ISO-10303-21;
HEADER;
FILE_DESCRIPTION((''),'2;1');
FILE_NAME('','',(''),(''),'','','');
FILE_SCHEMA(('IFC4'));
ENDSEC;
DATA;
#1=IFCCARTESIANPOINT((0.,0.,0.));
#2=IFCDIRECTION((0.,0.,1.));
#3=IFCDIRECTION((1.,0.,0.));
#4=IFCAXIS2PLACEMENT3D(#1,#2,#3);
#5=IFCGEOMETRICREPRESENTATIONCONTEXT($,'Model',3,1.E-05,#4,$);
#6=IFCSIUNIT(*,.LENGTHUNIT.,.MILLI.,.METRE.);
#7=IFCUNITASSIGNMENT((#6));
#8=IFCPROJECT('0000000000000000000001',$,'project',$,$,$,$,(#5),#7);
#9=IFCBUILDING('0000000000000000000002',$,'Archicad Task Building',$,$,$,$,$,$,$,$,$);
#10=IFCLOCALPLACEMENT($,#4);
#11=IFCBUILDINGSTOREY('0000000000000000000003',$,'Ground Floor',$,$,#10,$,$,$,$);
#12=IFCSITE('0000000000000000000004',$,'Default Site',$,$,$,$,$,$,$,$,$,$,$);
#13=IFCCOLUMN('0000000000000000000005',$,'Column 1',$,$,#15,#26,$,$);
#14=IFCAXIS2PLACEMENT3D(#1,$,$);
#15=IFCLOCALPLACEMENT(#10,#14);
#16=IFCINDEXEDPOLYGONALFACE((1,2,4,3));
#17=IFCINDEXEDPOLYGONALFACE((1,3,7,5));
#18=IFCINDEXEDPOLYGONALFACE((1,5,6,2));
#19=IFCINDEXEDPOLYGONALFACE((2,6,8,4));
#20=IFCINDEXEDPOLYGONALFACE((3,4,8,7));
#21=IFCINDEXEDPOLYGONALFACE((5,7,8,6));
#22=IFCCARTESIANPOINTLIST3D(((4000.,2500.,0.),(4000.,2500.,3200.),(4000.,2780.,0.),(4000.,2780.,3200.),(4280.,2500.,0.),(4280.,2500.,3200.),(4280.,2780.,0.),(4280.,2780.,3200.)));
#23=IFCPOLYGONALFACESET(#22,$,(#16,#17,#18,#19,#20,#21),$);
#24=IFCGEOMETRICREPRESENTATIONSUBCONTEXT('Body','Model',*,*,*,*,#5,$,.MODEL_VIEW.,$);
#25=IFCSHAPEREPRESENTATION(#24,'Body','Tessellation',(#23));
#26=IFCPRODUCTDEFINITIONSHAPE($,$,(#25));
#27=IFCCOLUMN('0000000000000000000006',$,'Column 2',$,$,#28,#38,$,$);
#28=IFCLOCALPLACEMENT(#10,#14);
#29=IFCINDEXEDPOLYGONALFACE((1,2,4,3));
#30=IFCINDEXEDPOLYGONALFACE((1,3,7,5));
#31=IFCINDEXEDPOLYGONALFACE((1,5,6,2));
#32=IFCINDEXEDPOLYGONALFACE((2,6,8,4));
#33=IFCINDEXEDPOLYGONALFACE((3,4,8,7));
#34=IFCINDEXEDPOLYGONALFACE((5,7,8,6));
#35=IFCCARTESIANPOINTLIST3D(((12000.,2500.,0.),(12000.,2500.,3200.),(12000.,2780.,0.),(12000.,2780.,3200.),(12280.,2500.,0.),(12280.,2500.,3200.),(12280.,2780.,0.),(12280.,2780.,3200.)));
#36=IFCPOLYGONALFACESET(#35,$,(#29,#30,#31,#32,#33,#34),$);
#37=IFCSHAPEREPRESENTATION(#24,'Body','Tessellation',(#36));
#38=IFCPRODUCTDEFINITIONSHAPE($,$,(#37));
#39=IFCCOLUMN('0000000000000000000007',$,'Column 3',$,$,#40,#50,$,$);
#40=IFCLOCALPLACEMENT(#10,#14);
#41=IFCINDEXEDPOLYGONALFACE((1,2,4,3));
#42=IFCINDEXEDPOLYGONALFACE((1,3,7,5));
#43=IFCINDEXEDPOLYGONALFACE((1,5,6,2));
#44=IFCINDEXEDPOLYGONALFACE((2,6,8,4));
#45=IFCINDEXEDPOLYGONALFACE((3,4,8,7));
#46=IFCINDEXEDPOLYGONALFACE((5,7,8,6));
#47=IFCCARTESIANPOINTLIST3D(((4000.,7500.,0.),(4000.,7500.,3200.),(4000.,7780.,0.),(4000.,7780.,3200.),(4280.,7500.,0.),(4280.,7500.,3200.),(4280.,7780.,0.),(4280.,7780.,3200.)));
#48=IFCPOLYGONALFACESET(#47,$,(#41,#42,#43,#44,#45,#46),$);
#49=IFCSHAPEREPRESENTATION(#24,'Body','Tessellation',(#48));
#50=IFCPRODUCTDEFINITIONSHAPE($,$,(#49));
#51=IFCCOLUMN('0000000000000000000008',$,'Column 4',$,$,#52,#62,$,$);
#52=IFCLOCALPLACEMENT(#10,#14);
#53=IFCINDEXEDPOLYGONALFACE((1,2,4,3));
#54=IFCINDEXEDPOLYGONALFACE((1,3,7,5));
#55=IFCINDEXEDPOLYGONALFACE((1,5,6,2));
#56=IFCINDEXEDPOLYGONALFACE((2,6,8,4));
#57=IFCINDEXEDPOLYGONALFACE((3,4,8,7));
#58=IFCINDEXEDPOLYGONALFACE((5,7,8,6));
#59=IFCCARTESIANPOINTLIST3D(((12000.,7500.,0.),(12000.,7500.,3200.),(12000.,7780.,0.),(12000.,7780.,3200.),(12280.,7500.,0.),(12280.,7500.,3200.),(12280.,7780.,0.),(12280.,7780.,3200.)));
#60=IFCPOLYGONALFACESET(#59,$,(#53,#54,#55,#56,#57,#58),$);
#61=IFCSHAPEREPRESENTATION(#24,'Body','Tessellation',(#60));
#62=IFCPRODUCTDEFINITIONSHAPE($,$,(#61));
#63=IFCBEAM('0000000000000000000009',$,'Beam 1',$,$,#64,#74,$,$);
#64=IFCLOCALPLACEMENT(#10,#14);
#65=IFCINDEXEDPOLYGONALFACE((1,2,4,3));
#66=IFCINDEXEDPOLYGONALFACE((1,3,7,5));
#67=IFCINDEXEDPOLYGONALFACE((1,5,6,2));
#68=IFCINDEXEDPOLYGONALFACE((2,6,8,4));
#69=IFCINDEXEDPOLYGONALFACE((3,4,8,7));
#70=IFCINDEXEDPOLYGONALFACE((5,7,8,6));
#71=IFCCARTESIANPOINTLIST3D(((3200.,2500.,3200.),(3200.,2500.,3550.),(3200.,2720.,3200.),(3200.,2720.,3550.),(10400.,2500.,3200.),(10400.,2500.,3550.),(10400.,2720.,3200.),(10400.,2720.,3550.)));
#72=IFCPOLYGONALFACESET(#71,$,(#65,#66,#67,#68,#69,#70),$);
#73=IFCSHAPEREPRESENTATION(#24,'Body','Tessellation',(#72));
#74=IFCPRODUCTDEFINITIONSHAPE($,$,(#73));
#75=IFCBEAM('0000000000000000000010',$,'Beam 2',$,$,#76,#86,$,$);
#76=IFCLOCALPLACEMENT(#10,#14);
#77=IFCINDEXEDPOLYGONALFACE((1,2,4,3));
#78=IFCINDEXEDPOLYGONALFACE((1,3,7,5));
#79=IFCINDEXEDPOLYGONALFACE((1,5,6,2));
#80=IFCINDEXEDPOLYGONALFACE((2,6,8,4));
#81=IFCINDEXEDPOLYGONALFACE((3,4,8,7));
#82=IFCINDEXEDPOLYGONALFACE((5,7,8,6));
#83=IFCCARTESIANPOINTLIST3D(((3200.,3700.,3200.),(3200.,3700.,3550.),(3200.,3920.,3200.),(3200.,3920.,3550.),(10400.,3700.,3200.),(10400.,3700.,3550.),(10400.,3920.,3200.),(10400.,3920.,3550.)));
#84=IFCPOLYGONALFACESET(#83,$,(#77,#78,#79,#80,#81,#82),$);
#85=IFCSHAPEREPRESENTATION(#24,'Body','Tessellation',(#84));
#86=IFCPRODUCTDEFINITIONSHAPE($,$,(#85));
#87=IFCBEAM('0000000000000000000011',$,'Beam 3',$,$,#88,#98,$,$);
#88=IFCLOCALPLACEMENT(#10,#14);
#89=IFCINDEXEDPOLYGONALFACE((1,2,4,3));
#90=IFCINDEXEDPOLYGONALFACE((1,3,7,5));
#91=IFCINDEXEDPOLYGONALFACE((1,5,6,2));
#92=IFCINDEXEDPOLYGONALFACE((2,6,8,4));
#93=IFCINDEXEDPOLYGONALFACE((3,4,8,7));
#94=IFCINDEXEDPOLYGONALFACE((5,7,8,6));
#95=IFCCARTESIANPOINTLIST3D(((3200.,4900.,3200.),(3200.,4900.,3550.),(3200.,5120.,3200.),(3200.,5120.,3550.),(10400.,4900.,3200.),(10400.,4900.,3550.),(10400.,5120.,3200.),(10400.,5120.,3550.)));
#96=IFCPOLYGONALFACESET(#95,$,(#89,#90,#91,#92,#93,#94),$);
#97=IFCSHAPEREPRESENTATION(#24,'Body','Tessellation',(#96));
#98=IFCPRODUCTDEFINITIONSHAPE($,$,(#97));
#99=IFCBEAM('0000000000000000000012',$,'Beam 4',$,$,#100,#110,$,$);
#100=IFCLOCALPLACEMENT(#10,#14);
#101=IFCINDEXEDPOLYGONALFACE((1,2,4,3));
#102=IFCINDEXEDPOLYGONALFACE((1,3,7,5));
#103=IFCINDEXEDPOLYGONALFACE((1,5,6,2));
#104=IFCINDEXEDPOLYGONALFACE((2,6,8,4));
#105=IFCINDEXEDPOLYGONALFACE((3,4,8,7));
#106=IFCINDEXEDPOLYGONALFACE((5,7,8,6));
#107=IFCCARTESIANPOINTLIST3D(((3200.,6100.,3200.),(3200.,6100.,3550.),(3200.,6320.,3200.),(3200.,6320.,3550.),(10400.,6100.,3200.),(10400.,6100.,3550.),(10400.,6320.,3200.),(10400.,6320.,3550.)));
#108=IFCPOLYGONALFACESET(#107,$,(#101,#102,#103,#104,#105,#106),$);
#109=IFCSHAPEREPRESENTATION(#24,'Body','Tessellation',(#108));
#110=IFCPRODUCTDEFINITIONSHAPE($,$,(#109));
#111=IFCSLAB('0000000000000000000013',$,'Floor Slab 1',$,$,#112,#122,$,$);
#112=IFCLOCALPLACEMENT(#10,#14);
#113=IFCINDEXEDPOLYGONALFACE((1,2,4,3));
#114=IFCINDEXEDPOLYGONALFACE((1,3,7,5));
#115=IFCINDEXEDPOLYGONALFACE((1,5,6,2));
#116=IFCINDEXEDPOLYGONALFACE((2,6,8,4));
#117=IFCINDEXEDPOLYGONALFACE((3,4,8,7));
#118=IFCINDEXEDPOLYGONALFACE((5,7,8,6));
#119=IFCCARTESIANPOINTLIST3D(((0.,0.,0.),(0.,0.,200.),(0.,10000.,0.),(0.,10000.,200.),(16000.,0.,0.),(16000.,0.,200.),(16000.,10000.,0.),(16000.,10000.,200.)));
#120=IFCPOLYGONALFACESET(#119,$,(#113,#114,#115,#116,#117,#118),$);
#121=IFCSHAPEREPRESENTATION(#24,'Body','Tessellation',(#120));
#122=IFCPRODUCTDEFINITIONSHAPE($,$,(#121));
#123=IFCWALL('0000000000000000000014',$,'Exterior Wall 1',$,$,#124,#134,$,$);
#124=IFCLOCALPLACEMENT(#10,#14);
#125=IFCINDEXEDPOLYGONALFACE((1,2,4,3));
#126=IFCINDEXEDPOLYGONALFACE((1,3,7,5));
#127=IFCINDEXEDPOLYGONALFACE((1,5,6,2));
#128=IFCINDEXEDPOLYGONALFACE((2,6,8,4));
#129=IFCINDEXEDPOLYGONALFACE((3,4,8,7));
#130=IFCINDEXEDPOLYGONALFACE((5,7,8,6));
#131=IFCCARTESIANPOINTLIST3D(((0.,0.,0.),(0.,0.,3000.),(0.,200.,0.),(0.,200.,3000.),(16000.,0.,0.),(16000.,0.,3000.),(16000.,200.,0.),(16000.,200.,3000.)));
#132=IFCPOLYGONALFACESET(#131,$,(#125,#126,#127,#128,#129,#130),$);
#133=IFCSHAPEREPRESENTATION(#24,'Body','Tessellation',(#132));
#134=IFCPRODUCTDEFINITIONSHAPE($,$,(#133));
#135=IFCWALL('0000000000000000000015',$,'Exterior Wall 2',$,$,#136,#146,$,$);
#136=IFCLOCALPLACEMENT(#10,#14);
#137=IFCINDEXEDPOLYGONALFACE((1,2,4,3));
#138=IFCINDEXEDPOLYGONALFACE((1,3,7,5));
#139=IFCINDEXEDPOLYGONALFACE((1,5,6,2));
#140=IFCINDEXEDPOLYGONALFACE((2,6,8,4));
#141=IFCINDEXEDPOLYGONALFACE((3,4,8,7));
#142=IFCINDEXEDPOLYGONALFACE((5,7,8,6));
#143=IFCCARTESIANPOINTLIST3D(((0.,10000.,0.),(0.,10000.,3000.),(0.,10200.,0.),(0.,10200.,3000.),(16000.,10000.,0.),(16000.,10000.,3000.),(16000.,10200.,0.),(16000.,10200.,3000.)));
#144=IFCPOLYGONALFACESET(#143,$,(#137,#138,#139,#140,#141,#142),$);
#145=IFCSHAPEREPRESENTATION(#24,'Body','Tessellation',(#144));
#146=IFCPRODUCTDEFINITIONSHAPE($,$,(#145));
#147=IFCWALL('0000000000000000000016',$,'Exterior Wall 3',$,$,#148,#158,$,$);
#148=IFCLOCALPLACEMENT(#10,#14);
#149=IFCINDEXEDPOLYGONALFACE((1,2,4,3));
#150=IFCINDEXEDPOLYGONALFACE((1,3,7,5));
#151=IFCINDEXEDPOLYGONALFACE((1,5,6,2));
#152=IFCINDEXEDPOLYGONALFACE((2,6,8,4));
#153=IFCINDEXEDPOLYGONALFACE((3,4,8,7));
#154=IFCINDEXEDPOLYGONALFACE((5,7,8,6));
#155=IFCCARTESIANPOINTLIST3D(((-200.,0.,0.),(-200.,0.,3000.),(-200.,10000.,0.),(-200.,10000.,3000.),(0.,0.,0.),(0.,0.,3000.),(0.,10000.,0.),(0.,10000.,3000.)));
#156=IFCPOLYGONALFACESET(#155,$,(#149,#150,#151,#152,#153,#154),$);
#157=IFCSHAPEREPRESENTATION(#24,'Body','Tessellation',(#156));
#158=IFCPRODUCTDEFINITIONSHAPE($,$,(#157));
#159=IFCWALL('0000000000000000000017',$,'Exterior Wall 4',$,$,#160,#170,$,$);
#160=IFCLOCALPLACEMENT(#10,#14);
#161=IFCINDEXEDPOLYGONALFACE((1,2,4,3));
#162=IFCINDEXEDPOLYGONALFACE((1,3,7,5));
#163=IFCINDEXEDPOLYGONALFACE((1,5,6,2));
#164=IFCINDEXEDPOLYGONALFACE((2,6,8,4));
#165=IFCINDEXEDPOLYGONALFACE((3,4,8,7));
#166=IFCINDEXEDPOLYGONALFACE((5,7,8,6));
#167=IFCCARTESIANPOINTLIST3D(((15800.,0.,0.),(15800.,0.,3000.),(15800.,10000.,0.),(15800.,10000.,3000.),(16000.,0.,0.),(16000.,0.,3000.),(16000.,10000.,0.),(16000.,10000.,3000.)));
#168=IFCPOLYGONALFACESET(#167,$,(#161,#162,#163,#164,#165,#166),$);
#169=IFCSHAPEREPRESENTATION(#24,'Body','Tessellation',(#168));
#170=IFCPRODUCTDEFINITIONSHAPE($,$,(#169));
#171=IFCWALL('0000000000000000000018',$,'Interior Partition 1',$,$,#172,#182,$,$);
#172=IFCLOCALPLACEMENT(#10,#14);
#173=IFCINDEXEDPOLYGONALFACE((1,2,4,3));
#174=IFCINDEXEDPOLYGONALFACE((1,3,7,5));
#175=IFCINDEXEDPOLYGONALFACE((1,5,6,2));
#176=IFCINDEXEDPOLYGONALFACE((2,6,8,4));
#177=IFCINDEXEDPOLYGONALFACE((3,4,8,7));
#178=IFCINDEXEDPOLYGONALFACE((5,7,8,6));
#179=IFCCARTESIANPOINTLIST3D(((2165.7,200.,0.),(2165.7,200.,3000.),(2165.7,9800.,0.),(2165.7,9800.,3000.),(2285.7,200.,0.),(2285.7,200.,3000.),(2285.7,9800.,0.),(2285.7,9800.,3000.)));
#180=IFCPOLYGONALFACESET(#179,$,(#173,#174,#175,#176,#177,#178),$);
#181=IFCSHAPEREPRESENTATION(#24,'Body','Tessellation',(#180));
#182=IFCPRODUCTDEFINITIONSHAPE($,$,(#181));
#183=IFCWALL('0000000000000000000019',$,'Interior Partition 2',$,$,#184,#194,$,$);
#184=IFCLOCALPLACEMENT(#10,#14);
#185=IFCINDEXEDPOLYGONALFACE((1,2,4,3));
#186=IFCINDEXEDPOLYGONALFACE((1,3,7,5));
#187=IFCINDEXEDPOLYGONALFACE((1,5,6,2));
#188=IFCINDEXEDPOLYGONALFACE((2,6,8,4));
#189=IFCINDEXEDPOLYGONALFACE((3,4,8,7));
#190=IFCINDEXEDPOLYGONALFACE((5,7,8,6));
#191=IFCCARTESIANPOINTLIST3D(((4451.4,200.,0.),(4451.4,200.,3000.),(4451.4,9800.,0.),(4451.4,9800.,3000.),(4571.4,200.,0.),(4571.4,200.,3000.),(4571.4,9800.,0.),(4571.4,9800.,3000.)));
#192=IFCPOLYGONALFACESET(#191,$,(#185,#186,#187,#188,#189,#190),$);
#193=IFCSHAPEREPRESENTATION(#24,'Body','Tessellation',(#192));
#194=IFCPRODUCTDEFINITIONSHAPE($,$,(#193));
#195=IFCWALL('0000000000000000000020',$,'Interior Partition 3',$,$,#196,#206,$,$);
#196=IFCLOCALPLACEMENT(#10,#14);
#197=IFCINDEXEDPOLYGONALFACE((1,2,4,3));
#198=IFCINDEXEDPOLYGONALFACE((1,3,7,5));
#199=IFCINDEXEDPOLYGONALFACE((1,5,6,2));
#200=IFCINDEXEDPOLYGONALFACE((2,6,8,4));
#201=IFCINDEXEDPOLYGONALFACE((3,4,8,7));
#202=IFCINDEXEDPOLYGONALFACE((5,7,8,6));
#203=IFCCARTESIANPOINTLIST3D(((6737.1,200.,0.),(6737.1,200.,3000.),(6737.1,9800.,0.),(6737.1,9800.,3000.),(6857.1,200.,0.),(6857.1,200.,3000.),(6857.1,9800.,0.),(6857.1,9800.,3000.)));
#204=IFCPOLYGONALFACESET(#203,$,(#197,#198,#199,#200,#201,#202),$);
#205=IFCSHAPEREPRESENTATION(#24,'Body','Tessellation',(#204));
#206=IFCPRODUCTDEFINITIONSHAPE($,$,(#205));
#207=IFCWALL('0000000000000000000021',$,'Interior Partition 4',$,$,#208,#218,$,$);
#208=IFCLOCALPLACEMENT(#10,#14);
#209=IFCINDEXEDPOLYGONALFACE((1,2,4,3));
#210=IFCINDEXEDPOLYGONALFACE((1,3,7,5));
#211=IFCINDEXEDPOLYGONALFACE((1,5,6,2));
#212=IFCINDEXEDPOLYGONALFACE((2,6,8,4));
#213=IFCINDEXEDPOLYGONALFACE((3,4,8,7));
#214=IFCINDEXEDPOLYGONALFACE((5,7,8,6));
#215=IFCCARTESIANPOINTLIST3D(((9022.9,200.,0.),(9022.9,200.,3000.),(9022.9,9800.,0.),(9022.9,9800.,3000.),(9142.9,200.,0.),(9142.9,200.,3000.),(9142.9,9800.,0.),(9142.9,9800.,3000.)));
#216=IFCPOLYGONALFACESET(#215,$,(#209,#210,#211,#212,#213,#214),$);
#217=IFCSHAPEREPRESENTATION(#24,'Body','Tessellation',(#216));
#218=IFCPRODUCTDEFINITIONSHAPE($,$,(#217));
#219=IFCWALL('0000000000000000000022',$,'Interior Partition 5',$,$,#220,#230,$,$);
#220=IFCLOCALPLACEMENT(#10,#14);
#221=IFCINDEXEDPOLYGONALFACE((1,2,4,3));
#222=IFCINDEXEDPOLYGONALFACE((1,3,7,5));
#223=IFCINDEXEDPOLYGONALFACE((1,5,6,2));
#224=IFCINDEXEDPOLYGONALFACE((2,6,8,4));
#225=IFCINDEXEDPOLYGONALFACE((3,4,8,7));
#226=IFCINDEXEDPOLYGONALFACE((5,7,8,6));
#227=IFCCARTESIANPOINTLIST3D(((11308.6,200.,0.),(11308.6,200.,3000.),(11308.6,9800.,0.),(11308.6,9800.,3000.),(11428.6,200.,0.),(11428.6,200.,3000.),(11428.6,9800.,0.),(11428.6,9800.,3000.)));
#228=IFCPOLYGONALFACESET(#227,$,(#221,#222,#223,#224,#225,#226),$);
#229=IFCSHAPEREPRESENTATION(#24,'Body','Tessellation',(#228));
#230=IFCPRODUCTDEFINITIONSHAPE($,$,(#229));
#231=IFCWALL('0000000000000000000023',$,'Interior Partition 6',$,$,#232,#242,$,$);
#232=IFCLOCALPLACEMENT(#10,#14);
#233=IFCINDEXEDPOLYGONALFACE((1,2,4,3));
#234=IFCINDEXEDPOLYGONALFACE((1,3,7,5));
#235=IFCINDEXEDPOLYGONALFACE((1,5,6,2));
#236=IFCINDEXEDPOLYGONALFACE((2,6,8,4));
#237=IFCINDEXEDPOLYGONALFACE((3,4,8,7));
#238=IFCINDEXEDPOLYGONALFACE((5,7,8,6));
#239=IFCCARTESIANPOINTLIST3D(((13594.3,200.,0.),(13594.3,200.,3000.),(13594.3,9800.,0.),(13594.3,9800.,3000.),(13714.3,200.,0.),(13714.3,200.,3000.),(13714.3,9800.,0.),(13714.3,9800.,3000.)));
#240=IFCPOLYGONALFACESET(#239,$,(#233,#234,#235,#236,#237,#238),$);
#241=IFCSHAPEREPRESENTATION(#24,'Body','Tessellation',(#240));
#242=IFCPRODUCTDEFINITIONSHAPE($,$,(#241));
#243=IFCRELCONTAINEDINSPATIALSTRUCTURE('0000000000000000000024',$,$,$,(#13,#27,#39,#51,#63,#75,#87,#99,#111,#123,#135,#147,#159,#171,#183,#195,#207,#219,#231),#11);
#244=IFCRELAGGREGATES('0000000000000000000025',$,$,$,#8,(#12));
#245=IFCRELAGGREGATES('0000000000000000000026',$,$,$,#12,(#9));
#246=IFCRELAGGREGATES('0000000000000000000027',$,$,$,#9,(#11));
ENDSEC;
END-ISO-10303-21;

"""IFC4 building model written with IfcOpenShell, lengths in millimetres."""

from ifc_helpers import new_model, si_unit, frame, origin_with_axes, place, context, subcontext, project, spatial, indexed_curve, outline, extrude, element, save


model = new_model("IFC4")

# Units and contexts
model_context = context("Model", 3, precision=1e-05, world=origin_with_axes())
body_context = subcontext(model_context, "Body", "Model", "MODEL_VIEW")
ifc_project = project(units=[si_unit("LENGTHUNIT", "METRE", prefix="MILLI")], contexts=[model_context])

# Site, building, storey
site = spatial("IfcSite", under=ifc_project, Name="Default Site")
building = spatial("IfcBuilding", under=site, Name="Archicad Task Building")
storey_placement = place(None, origin_with_axes())
storey = spatial("IfcBuildingStorey", under=building, at=storey_placement, Name="Ground Floor")

# Columns
for number, where, z_axis, x_axis, name in (
    (1, (4000.0, 2500.0, 0.0), (0.0, 0.0, 1.0), (1.0, 0.0, 0.0), "Column 1"),
    (2, (12000.0, 2500.0, 0.0), (0.0, 0.0, 1.0), (1.0, 0.0, 0.0), "Column 2"),
    (3, (4000.0, 7500.0, 0.0), (0.0, 0.0, 1.0), (1.0, 0.0, 0.0), "Column 3"),
    (4, (12000.0, 7500.0, 0.0), (0.0, 0.0, 1.0), (1.0, 0.0, 0.0), "Column 4"),
):
    element("IfcColumn", number, at=place(storey_placement, frame(where, z_axis=z_axis, x_axis=x_axis)), inside=storey, Name=name, context=body_context, shape_type="SweptSolid", body=[
        extrude(outline(indexed_curve([(0.0, 0.0), (0.0, 280.0), (280.0, 280.0), (280.0, 0.0), (0.0, 0.0)], self_intersect=False)), origin_with_axes(), (0.0, 0.0, 1.0), 3200.0),
    ])

# Beams
for number, where, z_axis, x_axis, name in (
    (5, (3200.0, 2500.0, 3200.0), (0.0, 0.0, 1.0), (1.0, 0.0, 0.0), "Beam 1"),
    (6, (3200.0, 3700.0, 3200.0), (0.0, 0.0, 1.0), (1.0, 0.0, 0.0), "Beam 2"),
    (7, (3200.0, 4900.0, 3200.0), (0.0, 0.0, 1.0), (1.0, 0.0, 0.0), "Beam 3"),
    (8, (3200.0, 6100.0, 3200.0), (0.0, 0.0, 1.0), (1.0, 0.0, 0.0), "Beam 4"),
):
    element("IfcBeam", number, at=place(storey_placement, frame(where, z_axis=z_axis, x_axis=x_axis)), inside=storey, Name=name, context=body_context, shape_type="SweptSolid", body=[
        extrude(outline(indexed_curve([(0.0, 0.0), (0.0, 220.0), (7200.0, 220.0), (7200.0, 0.0), (0.0, 0.0)], self_intersect=False)), origin_with_axes(), (0.0, 0.0, 1.0), 350.0),
    ])

# Slab
slab_placement = place(storey_placement, origin_with_axes())
element("IfcSlab", 9, at=slab_placement, inside=storey, Name="Floor Slab 1", context=body_context, shape_type="SweptSolid", body=[
    extrude(outline(indexed_curve([(0.0, 0.0), (16000.0, 0.0), (16000.0, 10000.0), (0.0, 10000.0), (0.0, 0.0)])), None, (0.0, 0.0, 1.0), 200.0),
])

# Walls
for number, where, z_axis, x_axis, name in (
    (10, (0.0, 0.0, 0.0), (0.0, 0.0, 1.0), (1.0, 0.0, 0.0), "Exterior Wall 1"),
    (11, (0.0, 10000.0, 0.0), (0.0, 0.0, 1.0), (1.0, 0.0, 0.0), "Exterior Wall 2"),
):
    element("IfcWall", number, at=place(storey_placement, frame(where, z_axis=z_axis, x_axis=x_axis)), inside=storey, Name=name, context=body_context, shape_type="SweptSolid", body=[
        extrude(outline(indexed_curve([(0.0, 0.0), (0.0, 200.0), (16000.0, 200.0), (16000.0, 0.0), (0.0, 0.0)], self_intersect=False)), origin_with_axes(), (0.0, 0.0, 1.0), 3000.0),
    ])
for number, where, z_axis, x_axis, name in (
    (12, (0.0, 0.0, 0.0), (0.0, 0.0, 1.0), (0.0, 1.0, 0.0), "Exterior Wall 3"),
    (13, (16000.0, 0.0, 0.0), (0.0, 0.0, 1.0), (0.0, 1.0, 0.0), "Exterior Wall 4"),
):
    element("IfcWall", number, at=place(storey_placement, frame(where, z_axis=z_axis, x_axis=x_axis)), inside=storey, Name=name, context=body_context, shape_type="SweptSolid", body=[
        extrude(outline(indexed_curve([(0.0, 0.0), (0.0, 200.0), (10000.0, 200.0), (10000.0, 0.0), (0.0, 0.0)], self_intersect=False)), origin_with_axes(), (0.0, 0.0, 1.0), 3000.0),
    ])
for number, where, z_axis, x_axis, name in (
    (14, (2285.7, 200.0, 0.0), (0.0, 0.0, 1.0), (0.0, 1.0, 0.0), "Interior Partition 1"),
    (15, (4571.4, 200.0, 0.0), (0.0, 0.0, 1.0), (0.0, 1.0, 0.0), "Interior Partition 2"),
    (16, (6857.1, 200.0, 0.0), (0.0, 0.0, 1.0), (0.0, 1.0, 0.0), "Interior Partition 3"),
    (17, (9142.9, 200.0, 0.0), (0.0, 0.0, 1.0), (0.0, 1.0, 0.0), "Interior Partition 4"),
    (18, (11428.6, 200.0, 0.0), (0.0, 0.0, 1.0), (0.0, 1.0, 0.0), "Interior Partition 5"),
    (19, (13714.3, 200.0, 0.0), (0.0, 0.0, 1.0), (0.0, 1.0, 0.0), "Interior Partition 6"),
):
    element("IfcWall", number, at=place(storey_placement, frame(where, z_axis=z_axis, x_axis=x_axis)), inside=storey, Name=name, context=body_context, shape_type="SweptSolid", body=[
        extrude(outline(indexed_curve([(0.0, 0.0), (0.0, 120.0), (9600.0, 120.0), (9600.0, 0.0), (0.0, 0.0)], self_intersect=False)), origin_with_axes(), (0.0, 0.0, 1.0), 3000.0),
    ])

save(model, "model.ifc")
